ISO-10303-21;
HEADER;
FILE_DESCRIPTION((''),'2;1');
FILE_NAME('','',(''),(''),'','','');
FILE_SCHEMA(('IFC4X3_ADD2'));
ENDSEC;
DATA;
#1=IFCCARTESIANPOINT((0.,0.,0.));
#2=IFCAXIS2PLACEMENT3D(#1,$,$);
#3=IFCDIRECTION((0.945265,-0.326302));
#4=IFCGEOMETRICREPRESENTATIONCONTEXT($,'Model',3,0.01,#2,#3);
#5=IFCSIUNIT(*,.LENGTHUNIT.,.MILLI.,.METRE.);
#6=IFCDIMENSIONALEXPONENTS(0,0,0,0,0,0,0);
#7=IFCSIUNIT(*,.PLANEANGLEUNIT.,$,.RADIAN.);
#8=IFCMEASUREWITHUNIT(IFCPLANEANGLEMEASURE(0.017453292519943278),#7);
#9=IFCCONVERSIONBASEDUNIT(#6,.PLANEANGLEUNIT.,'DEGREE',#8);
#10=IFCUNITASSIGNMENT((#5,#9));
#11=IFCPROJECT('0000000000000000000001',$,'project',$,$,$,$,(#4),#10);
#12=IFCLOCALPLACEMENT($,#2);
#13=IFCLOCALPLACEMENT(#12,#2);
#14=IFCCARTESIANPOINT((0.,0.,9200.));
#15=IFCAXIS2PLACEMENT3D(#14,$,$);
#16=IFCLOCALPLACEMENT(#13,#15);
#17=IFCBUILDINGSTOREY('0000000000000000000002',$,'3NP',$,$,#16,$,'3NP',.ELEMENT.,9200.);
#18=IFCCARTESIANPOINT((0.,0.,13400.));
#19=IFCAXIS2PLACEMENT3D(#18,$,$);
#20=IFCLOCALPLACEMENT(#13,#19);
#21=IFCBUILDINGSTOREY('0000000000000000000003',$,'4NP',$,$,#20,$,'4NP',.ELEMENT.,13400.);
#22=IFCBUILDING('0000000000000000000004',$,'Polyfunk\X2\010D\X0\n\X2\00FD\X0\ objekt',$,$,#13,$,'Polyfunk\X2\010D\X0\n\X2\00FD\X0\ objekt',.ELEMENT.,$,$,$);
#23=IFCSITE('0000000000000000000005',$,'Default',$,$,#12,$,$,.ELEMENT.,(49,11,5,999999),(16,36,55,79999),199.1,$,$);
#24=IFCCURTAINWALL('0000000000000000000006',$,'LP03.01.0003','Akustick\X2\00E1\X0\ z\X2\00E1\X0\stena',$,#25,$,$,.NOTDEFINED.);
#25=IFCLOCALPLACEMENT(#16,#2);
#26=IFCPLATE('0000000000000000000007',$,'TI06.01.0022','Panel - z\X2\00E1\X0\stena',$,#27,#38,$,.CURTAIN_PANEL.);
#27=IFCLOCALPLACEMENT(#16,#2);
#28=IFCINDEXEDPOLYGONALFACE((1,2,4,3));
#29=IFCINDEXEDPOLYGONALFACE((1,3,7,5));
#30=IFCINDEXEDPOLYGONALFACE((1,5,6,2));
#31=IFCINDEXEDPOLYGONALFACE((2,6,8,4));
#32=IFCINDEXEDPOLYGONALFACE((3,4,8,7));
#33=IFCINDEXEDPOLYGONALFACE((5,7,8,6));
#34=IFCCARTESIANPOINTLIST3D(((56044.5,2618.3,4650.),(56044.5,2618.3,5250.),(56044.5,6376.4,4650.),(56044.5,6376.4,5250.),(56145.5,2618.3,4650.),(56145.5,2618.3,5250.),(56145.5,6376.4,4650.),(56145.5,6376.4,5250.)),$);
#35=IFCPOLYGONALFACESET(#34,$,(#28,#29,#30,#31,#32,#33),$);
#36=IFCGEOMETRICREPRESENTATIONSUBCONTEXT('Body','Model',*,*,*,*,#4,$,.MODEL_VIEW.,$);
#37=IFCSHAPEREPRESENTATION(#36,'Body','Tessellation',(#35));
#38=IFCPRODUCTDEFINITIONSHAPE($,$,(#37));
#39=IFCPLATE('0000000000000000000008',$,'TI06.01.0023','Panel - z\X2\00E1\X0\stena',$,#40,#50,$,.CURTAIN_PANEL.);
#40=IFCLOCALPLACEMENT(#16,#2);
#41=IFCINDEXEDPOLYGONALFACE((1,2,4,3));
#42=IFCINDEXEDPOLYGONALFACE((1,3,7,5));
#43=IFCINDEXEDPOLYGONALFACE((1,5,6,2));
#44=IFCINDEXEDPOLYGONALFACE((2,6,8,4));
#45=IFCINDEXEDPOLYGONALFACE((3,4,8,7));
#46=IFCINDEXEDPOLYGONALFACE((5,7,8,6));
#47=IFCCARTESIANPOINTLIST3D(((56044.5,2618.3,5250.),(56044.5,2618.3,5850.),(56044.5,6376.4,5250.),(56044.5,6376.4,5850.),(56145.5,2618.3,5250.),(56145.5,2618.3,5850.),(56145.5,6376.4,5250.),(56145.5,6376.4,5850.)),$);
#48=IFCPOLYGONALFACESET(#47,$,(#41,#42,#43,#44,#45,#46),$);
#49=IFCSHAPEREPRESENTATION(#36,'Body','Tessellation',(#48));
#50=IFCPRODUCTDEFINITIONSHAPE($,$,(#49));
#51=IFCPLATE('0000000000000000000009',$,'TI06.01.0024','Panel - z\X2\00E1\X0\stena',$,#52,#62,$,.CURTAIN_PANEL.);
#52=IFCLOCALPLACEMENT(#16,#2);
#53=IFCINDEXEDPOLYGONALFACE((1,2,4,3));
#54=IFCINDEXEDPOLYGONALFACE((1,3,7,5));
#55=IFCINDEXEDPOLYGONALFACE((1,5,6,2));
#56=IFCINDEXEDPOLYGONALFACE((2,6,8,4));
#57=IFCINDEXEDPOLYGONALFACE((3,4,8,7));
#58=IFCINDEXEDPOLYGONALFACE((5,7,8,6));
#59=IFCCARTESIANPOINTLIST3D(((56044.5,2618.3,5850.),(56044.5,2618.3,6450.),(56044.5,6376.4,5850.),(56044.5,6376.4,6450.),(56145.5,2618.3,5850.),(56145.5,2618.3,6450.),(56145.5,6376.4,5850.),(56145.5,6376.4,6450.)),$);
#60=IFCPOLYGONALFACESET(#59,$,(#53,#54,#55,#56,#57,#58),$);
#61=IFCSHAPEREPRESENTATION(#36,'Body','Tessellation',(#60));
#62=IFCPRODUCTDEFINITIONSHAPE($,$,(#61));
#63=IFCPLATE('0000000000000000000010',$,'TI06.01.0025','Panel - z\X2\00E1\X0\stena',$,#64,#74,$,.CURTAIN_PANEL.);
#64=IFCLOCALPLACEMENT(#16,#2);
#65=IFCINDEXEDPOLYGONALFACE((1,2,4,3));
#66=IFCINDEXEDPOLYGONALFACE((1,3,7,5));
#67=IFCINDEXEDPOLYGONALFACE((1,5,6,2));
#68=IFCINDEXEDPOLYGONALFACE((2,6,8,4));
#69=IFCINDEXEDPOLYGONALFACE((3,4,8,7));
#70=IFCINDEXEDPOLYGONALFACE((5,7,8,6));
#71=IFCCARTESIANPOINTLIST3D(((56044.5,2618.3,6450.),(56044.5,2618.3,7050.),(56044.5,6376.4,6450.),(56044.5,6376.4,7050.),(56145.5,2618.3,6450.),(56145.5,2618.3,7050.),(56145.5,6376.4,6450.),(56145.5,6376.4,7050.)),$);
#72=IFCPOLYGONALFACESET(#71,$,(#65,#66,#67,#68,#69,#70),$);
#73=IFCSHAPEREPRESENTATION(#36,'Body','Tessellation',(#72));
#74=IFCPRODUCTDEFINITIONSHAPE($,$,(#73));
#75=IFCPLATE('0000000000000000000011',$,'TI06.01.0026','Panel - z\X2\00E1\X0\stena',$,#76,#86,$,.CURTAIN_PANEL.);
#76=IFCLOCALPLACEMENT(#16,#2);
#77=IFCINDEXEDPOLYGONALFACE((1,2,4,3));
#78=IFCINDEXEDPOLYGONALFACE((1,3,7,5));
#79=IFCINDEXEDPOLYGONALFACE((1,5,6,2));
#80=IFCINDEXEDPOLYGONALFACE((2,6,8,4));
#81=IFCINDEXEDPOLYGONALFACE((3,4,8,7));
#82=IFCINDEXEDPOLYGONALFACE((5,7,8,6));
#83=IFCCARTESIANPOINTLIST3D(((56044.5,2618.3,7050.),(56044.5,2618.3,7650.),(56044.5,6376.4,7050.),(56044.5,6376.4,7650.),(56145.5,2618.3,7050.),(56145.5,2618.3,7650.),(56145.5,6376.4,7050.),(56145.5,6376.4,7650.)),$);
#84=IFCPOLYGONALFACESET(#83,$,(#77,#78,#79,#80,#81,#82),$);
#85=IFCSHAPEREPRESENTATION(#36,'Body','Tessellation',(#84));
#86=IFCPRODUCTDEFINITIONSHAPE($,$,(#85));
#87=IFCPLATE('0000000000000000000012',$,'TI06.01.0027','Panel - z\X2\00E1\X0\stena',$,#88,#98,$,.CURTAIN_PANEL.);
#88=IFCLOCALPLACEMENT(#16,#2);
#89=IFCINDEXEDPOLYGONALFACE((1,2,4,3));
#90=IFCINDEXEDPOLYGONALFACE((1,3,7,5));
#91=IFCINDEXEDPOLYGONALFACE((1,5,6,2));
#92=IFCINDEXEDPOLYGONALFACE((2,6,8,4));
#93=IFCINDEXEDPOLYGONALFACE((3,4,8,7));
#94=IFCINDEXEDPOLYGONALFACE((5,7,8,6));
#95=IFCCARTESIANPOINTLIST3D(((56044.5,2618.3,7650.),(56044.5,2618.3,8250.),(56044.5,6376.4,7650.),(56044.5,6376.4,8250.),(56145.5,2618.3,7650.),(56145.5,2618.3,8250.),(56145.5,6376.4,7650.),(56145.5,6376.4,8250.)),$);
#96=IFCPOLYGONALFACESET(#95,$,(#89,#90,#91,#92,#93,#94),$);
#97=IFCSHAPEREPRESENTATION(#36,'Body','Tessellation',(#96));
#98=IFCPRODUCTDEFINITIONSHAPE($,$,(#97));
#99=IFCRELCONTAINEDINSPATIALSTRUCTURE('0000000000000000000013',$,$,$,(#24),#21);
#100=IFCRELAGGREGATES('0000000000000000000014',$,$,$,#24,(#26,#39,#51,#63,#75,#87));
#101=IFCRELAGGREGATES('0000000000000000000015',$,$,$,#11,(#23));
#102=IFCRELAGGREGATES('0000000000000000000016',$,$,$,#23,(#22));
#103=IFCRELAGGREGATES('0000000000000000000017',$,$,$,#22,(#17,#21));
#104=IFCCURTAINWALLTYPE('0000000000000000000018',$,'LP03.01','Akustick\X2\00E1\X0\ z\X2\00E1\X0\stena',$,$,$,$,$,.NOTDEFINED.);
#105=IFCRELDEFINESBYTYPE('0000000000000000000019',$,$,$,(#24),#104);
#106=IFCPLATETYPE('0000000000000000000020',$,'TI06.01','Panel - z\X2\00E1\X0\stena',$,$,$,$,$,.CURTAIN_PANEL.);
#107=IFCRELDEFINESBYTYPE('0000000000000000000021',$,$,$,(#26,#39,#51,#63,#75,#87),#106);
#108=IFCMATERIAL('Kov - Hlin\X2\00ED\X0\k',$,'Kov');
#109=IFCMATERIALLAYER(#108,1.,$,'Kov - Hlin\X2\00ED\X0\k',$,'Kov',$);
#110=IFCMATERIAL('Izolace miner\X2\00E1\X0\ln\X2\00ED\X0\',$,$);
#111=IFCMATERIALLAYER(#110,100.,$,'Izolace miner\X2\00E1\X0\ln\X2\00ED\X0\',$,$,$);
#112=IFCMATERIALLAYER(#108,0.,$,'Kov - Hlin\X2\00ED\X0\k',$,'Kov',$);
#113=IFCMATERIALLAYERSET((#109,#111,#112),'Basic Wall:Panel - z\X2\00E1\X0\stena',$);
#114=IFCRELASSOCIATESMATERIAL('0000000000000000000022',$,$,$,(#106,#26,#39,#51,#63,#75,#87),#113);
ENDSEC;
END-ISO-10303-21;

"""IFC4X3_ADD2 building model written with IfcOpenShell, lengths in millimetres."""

from ifc_helpers import new_model, entity, si_unit, converted_unit, direction, frame, frame_2d, origin, place, context, subcontext, project, spatial, rectangle, extrude, material, layer, layer_set, layer_usage, type_object, element, aggregate, save


model = new_model("IFC4X3_ADD2")

# Units and contexts
model_context = context("Model", 3, precision=0.01, world=origin(), true_north=direction((0.945265, -0.326302)))
body_context = subcontext(model_context, "Body", "Model", "MODEL_VIEW")
ifc_project = project(units=[si_unit("LENGTHUNIT", "METRE", prefix="MILLI"), converted_unit("PLANEANGLEUNIT", "DEGREE", entity("IfcPlaneAngleMeasure", 0.017453292519943278), si_unit("PLANEANGLEUNIT", "RADIAN"), dimensions=[0, 0, 0, 0, 0, 0, 0])], contexts=[model_context])

# Site, building, storey
site_placement = place(None, origin())
site = spatial("IfcSite", under=ifc_project, at=site_placement, Name="Default", CompositionType="ELEMENT", RefLatitude=(49, 11, 5, 999999), RefLongitude=(16, 36, 55, 79999), RefElevation=199.1)
building_placement = place(site_placement, origin())
building = spatial("IfcBuilding", under=site, at=building_placement, Name="Polyfunkčný objekt", LongName="Polyfunkčný objekt", CompositionType="ELEMENT")
storey_1_placement = place(building_placement, frame((0.0, 0.0, 9200.0)))
storey_1 = spatial("IfcBuildingStorey", under=building, at=storey_1_placement, Name="3NP", LongName="3NP", CompositionType="ELEMENT", Elevation=9200.0)

# Shared definitions
storey_2_placement = place(building_placement, frame((0.0, 0.0, 13400.0)))
storey_2 = spatial("IfcBuildingStorey", under=building, at=storey_2_placement, Name="4NP", LongName="4NP", CompositionType="ELEMENT", Elevation=13400.0)

# Shared definitions
curtain_wall_type_1 = type_object("IfcCurtainWallType", Name="LP03.01", Description="Akustická zástena", PredefinedType="NOTDEFINED")

# Curtain wall, plates
curtain_wall_1_placement = place(storey_2_placement, frame((0.0, 0.0, -13400.0)))
curtain_wall_1 = element("IfcCurtainWall", 1, at=curtain_wall_1_placement, inside=storey_2, type_object=curtain_wall_type_1, Name="LP03.01.0003", Description="Akustická zástena", PredefinedType="NOTDEFINED")
ifc_material_1 = material(Name="Kov - Hliník", Category="Kov")
ifc_layer_1 = layer(ifc_material_1, 1.0, Name="Kov - Hliník", Category="Kov")
ifc_material_2 = material(Name="Izolace minerální")
ifc_layer_2 = layer(ifc_material_2, 100.0, Name="Izolace minerální")
ifc_layer_3 = layer(ifc_material_1, 0.0, Name="Kov - Hliník", Category="Kov")
ifc_layer_set = layer_set([ifc_layer_1, ifc_layer_2, ifc_layer_3], Name="Basic Wall:Panel - zástena")
ifc_layer_usage_1 = layer_usage(ifc_layer_set, "AXIS2", "NEGATIVE", 50.5)
plate_type = type_object("IfcPlateType", Name="TI06.01", Description="Panel - zástena", PredefinedType="CURTAIN_PANEL", material=ifc_layer_set)
plate_1_placement = place(storey_2_placement, frame((56095.0, 2618.3, 450.0), z_axis=(0.0, 0.0, 1.0), x_axis=(0.0, 1.0, 0.0)))
plate_1 = element("IfcPlate", 2, at=plate_1_placement, type_object=plate_type, material=ifc_layer_usage_1, Name="TI06.01.0022", Description="Panel - zástena", PredefinedType="CURTAIN_PANEL", context=body_context, shape_type="SweptSolid", body=[
    extrude(rectangle(XDim=101.0, YDim=3758.1, at=frame_2d((0.0, 0.0), x_axis=(1.0, 0.0))), frame((1879.0, 0.0, 0.0), z_axis=(0.0, 0.0, 1.0), x_axis=(0.0, 1.0, 0.0)), (0.0, 0.0, 1.0), 600.0),
])
ifc_layer_usage_2 = layer_usage(ifc_layer_set, "AXIS2", "NEGATIVE", 50.5)
plate_2_placement = place(storey_2_placement, frame((56095.0, 2618.3, 1050.0), z_axis=(0.0, 0.0, 1.0), x_axis=(0.0, 1.0, 0.0)))
plate_2 = element("IfcPlate", 3, at=plate_2_placement, type_object=plate_type, material=ifc_layer_usage_2, Name="TI06.01.0023", Description="Panel - zástena", PredefinedType="CURTAIN_PANEL", context=body_context, shape_type="SweptSolid", body=[
    extrude(rectangle(XDim=101.0, YDim=3758.1, at=frame_2d((0.0, 0.0), x_axis=(1.0, 0.0))), frame((1879.0, 0.0, 0.0), z_axis=(0.0, 0.0, 1.0), x_axis=(0.0, 1.0, 0.0)), (0.0, 0.0, 1.0), 600.0),
])
ifc_layer_usage_3 = layer_usage(ifc_layer_set, "AXIS2", "NEGATIVE", 50.5)
plate_3_placement = place(storey_2_placement, frame((56095.0, 2618.3, 1650.0), z_axis=(0.0, 0.0, 1.0), x_axis=(0.0, 1.0, 0.0)))
plate_3 = element("IfcPlate", 4, at=plate_3_placement, type_object=plate_type, material=ifc_layer_usage_3, Name="TI06.01.0024", Description="Panel - zástena", PredefinedType="CURTAIN_PANEL", context=body_context, shape_type="SweptSolid", body=[
    extrude(rectangle(XDim=101.0, YDim=3758.1, at=frame_2d((0.0, 0.0), x_axis=(1.0, 0.0))), frame((1879.0, 0.0, 0.0), z_axis=(0.0, 0.0, 1.0), x_axis=(0.0, 1.0, 0.0)), (0.0, 0.0, 1.0), 600.0),
])
ifc_layer_usage_4 = layer_usage(ifc_layer_set, "AXIS2", "NEGATIVE", 50.5)
plate_4_placement = place(storey_2_placement, frame((56095.0, 2618.3, 2250.0), z_axis=(0.0, 0.0, 1.0), x_axis=(0.0, 1.0, 0.0)))
plate_4 = element("IfcPlate", 5, at=plate_4_placement, type_object=plate_type, material=ifc_layer_usage_4, Name="TI06.01.0025", Description="Panel - zástena", PredefinedType="CURTAIN_PANEL", context=body_context, shape_type="SweptSolid", body=[
    extrude(rectangle(XDim=101.0, YDim=3758.1, at=frame_2d((0.0, 0.0), x_axis=(1.0, 0.0))), frame((1879.0, 0.0, 0.0), z_axis=(0.0, 0.0, 1.0), x_axis=(0.0, 1.0, 0.0)), (0.0, 0.0, 1.0), 600.0),
])
ifc_layer_usage_5 = layer_usage(ifc_layer_set, "AXIS2", "NEGATIVE", 50.5)
plate_5_placement = place(storey_2_placement, frame((56095.0, 2618.3, 2850.0), z_axis=(0.0, 0.0, 1.0), x_axis=(0.0, 1.0, 0.0)))
plate_5 = element("IfcPlate", 6, at=plate_5_placement, type_object=plate_type, material=ifc_layer_usage_5, Name="TI06.01.0026", Description="Panel - zástena", PredefinedType="CURTAIN_PANEL", context=body_context, shape_type="SweptSolid", body=[
    extrude(rectangle(XDim=101.0, YDim=3758.1, at=frame_2d((0.0, 0.0), x_axis=(1.0, 0.0))), frame((1879.0, 0.0, 0.0), z_axis=(0.0, 0.0, 1.0), x_axis=(0.0, 1.0, 0.0)), (0.0, 0.0, 1.0), 600.0),
])
ifc_layer_usage_6 = layer_usage(ifc_layer_set, "AXIS2", "NEGATIVE", 50.5)
plate_6_placement = place(storey_2_placement, frame((56095.0, 2618.3, 3450.0), z_axis=(0.0, 0.0, 1.0), x_axis=(0.0, 1.0, 0.0)))
plate_6 = element("IfcPlate", 7, at=plate_6_placement, type_object=plate_type, material=ifc_layer_usage_6, Name="TI06.01.0027", Description="Panel - zástena", PredefinedType="CURTAIN_PANEL", context=body_context, shape_type="SweptSolid", body=[
    extrude(rectangle(XDim=101.0, YDim=3758.1, at=frame_2d((0.0, 0.0), x_axis=(1.0, 0.0))), frame((1879.0, 0.0, 0.0), z_axis=(0.0, 0.0, 1.0), x_axis=(0.0, 1.0, 0.0)), (0.0, 0.0, 1.0), 600.0),
])
aggregate(curtain_wall_1, [plate_1, plate_2, plate_3, plate_4, plate_5, plate_6])

save(model, "model.ifc")
